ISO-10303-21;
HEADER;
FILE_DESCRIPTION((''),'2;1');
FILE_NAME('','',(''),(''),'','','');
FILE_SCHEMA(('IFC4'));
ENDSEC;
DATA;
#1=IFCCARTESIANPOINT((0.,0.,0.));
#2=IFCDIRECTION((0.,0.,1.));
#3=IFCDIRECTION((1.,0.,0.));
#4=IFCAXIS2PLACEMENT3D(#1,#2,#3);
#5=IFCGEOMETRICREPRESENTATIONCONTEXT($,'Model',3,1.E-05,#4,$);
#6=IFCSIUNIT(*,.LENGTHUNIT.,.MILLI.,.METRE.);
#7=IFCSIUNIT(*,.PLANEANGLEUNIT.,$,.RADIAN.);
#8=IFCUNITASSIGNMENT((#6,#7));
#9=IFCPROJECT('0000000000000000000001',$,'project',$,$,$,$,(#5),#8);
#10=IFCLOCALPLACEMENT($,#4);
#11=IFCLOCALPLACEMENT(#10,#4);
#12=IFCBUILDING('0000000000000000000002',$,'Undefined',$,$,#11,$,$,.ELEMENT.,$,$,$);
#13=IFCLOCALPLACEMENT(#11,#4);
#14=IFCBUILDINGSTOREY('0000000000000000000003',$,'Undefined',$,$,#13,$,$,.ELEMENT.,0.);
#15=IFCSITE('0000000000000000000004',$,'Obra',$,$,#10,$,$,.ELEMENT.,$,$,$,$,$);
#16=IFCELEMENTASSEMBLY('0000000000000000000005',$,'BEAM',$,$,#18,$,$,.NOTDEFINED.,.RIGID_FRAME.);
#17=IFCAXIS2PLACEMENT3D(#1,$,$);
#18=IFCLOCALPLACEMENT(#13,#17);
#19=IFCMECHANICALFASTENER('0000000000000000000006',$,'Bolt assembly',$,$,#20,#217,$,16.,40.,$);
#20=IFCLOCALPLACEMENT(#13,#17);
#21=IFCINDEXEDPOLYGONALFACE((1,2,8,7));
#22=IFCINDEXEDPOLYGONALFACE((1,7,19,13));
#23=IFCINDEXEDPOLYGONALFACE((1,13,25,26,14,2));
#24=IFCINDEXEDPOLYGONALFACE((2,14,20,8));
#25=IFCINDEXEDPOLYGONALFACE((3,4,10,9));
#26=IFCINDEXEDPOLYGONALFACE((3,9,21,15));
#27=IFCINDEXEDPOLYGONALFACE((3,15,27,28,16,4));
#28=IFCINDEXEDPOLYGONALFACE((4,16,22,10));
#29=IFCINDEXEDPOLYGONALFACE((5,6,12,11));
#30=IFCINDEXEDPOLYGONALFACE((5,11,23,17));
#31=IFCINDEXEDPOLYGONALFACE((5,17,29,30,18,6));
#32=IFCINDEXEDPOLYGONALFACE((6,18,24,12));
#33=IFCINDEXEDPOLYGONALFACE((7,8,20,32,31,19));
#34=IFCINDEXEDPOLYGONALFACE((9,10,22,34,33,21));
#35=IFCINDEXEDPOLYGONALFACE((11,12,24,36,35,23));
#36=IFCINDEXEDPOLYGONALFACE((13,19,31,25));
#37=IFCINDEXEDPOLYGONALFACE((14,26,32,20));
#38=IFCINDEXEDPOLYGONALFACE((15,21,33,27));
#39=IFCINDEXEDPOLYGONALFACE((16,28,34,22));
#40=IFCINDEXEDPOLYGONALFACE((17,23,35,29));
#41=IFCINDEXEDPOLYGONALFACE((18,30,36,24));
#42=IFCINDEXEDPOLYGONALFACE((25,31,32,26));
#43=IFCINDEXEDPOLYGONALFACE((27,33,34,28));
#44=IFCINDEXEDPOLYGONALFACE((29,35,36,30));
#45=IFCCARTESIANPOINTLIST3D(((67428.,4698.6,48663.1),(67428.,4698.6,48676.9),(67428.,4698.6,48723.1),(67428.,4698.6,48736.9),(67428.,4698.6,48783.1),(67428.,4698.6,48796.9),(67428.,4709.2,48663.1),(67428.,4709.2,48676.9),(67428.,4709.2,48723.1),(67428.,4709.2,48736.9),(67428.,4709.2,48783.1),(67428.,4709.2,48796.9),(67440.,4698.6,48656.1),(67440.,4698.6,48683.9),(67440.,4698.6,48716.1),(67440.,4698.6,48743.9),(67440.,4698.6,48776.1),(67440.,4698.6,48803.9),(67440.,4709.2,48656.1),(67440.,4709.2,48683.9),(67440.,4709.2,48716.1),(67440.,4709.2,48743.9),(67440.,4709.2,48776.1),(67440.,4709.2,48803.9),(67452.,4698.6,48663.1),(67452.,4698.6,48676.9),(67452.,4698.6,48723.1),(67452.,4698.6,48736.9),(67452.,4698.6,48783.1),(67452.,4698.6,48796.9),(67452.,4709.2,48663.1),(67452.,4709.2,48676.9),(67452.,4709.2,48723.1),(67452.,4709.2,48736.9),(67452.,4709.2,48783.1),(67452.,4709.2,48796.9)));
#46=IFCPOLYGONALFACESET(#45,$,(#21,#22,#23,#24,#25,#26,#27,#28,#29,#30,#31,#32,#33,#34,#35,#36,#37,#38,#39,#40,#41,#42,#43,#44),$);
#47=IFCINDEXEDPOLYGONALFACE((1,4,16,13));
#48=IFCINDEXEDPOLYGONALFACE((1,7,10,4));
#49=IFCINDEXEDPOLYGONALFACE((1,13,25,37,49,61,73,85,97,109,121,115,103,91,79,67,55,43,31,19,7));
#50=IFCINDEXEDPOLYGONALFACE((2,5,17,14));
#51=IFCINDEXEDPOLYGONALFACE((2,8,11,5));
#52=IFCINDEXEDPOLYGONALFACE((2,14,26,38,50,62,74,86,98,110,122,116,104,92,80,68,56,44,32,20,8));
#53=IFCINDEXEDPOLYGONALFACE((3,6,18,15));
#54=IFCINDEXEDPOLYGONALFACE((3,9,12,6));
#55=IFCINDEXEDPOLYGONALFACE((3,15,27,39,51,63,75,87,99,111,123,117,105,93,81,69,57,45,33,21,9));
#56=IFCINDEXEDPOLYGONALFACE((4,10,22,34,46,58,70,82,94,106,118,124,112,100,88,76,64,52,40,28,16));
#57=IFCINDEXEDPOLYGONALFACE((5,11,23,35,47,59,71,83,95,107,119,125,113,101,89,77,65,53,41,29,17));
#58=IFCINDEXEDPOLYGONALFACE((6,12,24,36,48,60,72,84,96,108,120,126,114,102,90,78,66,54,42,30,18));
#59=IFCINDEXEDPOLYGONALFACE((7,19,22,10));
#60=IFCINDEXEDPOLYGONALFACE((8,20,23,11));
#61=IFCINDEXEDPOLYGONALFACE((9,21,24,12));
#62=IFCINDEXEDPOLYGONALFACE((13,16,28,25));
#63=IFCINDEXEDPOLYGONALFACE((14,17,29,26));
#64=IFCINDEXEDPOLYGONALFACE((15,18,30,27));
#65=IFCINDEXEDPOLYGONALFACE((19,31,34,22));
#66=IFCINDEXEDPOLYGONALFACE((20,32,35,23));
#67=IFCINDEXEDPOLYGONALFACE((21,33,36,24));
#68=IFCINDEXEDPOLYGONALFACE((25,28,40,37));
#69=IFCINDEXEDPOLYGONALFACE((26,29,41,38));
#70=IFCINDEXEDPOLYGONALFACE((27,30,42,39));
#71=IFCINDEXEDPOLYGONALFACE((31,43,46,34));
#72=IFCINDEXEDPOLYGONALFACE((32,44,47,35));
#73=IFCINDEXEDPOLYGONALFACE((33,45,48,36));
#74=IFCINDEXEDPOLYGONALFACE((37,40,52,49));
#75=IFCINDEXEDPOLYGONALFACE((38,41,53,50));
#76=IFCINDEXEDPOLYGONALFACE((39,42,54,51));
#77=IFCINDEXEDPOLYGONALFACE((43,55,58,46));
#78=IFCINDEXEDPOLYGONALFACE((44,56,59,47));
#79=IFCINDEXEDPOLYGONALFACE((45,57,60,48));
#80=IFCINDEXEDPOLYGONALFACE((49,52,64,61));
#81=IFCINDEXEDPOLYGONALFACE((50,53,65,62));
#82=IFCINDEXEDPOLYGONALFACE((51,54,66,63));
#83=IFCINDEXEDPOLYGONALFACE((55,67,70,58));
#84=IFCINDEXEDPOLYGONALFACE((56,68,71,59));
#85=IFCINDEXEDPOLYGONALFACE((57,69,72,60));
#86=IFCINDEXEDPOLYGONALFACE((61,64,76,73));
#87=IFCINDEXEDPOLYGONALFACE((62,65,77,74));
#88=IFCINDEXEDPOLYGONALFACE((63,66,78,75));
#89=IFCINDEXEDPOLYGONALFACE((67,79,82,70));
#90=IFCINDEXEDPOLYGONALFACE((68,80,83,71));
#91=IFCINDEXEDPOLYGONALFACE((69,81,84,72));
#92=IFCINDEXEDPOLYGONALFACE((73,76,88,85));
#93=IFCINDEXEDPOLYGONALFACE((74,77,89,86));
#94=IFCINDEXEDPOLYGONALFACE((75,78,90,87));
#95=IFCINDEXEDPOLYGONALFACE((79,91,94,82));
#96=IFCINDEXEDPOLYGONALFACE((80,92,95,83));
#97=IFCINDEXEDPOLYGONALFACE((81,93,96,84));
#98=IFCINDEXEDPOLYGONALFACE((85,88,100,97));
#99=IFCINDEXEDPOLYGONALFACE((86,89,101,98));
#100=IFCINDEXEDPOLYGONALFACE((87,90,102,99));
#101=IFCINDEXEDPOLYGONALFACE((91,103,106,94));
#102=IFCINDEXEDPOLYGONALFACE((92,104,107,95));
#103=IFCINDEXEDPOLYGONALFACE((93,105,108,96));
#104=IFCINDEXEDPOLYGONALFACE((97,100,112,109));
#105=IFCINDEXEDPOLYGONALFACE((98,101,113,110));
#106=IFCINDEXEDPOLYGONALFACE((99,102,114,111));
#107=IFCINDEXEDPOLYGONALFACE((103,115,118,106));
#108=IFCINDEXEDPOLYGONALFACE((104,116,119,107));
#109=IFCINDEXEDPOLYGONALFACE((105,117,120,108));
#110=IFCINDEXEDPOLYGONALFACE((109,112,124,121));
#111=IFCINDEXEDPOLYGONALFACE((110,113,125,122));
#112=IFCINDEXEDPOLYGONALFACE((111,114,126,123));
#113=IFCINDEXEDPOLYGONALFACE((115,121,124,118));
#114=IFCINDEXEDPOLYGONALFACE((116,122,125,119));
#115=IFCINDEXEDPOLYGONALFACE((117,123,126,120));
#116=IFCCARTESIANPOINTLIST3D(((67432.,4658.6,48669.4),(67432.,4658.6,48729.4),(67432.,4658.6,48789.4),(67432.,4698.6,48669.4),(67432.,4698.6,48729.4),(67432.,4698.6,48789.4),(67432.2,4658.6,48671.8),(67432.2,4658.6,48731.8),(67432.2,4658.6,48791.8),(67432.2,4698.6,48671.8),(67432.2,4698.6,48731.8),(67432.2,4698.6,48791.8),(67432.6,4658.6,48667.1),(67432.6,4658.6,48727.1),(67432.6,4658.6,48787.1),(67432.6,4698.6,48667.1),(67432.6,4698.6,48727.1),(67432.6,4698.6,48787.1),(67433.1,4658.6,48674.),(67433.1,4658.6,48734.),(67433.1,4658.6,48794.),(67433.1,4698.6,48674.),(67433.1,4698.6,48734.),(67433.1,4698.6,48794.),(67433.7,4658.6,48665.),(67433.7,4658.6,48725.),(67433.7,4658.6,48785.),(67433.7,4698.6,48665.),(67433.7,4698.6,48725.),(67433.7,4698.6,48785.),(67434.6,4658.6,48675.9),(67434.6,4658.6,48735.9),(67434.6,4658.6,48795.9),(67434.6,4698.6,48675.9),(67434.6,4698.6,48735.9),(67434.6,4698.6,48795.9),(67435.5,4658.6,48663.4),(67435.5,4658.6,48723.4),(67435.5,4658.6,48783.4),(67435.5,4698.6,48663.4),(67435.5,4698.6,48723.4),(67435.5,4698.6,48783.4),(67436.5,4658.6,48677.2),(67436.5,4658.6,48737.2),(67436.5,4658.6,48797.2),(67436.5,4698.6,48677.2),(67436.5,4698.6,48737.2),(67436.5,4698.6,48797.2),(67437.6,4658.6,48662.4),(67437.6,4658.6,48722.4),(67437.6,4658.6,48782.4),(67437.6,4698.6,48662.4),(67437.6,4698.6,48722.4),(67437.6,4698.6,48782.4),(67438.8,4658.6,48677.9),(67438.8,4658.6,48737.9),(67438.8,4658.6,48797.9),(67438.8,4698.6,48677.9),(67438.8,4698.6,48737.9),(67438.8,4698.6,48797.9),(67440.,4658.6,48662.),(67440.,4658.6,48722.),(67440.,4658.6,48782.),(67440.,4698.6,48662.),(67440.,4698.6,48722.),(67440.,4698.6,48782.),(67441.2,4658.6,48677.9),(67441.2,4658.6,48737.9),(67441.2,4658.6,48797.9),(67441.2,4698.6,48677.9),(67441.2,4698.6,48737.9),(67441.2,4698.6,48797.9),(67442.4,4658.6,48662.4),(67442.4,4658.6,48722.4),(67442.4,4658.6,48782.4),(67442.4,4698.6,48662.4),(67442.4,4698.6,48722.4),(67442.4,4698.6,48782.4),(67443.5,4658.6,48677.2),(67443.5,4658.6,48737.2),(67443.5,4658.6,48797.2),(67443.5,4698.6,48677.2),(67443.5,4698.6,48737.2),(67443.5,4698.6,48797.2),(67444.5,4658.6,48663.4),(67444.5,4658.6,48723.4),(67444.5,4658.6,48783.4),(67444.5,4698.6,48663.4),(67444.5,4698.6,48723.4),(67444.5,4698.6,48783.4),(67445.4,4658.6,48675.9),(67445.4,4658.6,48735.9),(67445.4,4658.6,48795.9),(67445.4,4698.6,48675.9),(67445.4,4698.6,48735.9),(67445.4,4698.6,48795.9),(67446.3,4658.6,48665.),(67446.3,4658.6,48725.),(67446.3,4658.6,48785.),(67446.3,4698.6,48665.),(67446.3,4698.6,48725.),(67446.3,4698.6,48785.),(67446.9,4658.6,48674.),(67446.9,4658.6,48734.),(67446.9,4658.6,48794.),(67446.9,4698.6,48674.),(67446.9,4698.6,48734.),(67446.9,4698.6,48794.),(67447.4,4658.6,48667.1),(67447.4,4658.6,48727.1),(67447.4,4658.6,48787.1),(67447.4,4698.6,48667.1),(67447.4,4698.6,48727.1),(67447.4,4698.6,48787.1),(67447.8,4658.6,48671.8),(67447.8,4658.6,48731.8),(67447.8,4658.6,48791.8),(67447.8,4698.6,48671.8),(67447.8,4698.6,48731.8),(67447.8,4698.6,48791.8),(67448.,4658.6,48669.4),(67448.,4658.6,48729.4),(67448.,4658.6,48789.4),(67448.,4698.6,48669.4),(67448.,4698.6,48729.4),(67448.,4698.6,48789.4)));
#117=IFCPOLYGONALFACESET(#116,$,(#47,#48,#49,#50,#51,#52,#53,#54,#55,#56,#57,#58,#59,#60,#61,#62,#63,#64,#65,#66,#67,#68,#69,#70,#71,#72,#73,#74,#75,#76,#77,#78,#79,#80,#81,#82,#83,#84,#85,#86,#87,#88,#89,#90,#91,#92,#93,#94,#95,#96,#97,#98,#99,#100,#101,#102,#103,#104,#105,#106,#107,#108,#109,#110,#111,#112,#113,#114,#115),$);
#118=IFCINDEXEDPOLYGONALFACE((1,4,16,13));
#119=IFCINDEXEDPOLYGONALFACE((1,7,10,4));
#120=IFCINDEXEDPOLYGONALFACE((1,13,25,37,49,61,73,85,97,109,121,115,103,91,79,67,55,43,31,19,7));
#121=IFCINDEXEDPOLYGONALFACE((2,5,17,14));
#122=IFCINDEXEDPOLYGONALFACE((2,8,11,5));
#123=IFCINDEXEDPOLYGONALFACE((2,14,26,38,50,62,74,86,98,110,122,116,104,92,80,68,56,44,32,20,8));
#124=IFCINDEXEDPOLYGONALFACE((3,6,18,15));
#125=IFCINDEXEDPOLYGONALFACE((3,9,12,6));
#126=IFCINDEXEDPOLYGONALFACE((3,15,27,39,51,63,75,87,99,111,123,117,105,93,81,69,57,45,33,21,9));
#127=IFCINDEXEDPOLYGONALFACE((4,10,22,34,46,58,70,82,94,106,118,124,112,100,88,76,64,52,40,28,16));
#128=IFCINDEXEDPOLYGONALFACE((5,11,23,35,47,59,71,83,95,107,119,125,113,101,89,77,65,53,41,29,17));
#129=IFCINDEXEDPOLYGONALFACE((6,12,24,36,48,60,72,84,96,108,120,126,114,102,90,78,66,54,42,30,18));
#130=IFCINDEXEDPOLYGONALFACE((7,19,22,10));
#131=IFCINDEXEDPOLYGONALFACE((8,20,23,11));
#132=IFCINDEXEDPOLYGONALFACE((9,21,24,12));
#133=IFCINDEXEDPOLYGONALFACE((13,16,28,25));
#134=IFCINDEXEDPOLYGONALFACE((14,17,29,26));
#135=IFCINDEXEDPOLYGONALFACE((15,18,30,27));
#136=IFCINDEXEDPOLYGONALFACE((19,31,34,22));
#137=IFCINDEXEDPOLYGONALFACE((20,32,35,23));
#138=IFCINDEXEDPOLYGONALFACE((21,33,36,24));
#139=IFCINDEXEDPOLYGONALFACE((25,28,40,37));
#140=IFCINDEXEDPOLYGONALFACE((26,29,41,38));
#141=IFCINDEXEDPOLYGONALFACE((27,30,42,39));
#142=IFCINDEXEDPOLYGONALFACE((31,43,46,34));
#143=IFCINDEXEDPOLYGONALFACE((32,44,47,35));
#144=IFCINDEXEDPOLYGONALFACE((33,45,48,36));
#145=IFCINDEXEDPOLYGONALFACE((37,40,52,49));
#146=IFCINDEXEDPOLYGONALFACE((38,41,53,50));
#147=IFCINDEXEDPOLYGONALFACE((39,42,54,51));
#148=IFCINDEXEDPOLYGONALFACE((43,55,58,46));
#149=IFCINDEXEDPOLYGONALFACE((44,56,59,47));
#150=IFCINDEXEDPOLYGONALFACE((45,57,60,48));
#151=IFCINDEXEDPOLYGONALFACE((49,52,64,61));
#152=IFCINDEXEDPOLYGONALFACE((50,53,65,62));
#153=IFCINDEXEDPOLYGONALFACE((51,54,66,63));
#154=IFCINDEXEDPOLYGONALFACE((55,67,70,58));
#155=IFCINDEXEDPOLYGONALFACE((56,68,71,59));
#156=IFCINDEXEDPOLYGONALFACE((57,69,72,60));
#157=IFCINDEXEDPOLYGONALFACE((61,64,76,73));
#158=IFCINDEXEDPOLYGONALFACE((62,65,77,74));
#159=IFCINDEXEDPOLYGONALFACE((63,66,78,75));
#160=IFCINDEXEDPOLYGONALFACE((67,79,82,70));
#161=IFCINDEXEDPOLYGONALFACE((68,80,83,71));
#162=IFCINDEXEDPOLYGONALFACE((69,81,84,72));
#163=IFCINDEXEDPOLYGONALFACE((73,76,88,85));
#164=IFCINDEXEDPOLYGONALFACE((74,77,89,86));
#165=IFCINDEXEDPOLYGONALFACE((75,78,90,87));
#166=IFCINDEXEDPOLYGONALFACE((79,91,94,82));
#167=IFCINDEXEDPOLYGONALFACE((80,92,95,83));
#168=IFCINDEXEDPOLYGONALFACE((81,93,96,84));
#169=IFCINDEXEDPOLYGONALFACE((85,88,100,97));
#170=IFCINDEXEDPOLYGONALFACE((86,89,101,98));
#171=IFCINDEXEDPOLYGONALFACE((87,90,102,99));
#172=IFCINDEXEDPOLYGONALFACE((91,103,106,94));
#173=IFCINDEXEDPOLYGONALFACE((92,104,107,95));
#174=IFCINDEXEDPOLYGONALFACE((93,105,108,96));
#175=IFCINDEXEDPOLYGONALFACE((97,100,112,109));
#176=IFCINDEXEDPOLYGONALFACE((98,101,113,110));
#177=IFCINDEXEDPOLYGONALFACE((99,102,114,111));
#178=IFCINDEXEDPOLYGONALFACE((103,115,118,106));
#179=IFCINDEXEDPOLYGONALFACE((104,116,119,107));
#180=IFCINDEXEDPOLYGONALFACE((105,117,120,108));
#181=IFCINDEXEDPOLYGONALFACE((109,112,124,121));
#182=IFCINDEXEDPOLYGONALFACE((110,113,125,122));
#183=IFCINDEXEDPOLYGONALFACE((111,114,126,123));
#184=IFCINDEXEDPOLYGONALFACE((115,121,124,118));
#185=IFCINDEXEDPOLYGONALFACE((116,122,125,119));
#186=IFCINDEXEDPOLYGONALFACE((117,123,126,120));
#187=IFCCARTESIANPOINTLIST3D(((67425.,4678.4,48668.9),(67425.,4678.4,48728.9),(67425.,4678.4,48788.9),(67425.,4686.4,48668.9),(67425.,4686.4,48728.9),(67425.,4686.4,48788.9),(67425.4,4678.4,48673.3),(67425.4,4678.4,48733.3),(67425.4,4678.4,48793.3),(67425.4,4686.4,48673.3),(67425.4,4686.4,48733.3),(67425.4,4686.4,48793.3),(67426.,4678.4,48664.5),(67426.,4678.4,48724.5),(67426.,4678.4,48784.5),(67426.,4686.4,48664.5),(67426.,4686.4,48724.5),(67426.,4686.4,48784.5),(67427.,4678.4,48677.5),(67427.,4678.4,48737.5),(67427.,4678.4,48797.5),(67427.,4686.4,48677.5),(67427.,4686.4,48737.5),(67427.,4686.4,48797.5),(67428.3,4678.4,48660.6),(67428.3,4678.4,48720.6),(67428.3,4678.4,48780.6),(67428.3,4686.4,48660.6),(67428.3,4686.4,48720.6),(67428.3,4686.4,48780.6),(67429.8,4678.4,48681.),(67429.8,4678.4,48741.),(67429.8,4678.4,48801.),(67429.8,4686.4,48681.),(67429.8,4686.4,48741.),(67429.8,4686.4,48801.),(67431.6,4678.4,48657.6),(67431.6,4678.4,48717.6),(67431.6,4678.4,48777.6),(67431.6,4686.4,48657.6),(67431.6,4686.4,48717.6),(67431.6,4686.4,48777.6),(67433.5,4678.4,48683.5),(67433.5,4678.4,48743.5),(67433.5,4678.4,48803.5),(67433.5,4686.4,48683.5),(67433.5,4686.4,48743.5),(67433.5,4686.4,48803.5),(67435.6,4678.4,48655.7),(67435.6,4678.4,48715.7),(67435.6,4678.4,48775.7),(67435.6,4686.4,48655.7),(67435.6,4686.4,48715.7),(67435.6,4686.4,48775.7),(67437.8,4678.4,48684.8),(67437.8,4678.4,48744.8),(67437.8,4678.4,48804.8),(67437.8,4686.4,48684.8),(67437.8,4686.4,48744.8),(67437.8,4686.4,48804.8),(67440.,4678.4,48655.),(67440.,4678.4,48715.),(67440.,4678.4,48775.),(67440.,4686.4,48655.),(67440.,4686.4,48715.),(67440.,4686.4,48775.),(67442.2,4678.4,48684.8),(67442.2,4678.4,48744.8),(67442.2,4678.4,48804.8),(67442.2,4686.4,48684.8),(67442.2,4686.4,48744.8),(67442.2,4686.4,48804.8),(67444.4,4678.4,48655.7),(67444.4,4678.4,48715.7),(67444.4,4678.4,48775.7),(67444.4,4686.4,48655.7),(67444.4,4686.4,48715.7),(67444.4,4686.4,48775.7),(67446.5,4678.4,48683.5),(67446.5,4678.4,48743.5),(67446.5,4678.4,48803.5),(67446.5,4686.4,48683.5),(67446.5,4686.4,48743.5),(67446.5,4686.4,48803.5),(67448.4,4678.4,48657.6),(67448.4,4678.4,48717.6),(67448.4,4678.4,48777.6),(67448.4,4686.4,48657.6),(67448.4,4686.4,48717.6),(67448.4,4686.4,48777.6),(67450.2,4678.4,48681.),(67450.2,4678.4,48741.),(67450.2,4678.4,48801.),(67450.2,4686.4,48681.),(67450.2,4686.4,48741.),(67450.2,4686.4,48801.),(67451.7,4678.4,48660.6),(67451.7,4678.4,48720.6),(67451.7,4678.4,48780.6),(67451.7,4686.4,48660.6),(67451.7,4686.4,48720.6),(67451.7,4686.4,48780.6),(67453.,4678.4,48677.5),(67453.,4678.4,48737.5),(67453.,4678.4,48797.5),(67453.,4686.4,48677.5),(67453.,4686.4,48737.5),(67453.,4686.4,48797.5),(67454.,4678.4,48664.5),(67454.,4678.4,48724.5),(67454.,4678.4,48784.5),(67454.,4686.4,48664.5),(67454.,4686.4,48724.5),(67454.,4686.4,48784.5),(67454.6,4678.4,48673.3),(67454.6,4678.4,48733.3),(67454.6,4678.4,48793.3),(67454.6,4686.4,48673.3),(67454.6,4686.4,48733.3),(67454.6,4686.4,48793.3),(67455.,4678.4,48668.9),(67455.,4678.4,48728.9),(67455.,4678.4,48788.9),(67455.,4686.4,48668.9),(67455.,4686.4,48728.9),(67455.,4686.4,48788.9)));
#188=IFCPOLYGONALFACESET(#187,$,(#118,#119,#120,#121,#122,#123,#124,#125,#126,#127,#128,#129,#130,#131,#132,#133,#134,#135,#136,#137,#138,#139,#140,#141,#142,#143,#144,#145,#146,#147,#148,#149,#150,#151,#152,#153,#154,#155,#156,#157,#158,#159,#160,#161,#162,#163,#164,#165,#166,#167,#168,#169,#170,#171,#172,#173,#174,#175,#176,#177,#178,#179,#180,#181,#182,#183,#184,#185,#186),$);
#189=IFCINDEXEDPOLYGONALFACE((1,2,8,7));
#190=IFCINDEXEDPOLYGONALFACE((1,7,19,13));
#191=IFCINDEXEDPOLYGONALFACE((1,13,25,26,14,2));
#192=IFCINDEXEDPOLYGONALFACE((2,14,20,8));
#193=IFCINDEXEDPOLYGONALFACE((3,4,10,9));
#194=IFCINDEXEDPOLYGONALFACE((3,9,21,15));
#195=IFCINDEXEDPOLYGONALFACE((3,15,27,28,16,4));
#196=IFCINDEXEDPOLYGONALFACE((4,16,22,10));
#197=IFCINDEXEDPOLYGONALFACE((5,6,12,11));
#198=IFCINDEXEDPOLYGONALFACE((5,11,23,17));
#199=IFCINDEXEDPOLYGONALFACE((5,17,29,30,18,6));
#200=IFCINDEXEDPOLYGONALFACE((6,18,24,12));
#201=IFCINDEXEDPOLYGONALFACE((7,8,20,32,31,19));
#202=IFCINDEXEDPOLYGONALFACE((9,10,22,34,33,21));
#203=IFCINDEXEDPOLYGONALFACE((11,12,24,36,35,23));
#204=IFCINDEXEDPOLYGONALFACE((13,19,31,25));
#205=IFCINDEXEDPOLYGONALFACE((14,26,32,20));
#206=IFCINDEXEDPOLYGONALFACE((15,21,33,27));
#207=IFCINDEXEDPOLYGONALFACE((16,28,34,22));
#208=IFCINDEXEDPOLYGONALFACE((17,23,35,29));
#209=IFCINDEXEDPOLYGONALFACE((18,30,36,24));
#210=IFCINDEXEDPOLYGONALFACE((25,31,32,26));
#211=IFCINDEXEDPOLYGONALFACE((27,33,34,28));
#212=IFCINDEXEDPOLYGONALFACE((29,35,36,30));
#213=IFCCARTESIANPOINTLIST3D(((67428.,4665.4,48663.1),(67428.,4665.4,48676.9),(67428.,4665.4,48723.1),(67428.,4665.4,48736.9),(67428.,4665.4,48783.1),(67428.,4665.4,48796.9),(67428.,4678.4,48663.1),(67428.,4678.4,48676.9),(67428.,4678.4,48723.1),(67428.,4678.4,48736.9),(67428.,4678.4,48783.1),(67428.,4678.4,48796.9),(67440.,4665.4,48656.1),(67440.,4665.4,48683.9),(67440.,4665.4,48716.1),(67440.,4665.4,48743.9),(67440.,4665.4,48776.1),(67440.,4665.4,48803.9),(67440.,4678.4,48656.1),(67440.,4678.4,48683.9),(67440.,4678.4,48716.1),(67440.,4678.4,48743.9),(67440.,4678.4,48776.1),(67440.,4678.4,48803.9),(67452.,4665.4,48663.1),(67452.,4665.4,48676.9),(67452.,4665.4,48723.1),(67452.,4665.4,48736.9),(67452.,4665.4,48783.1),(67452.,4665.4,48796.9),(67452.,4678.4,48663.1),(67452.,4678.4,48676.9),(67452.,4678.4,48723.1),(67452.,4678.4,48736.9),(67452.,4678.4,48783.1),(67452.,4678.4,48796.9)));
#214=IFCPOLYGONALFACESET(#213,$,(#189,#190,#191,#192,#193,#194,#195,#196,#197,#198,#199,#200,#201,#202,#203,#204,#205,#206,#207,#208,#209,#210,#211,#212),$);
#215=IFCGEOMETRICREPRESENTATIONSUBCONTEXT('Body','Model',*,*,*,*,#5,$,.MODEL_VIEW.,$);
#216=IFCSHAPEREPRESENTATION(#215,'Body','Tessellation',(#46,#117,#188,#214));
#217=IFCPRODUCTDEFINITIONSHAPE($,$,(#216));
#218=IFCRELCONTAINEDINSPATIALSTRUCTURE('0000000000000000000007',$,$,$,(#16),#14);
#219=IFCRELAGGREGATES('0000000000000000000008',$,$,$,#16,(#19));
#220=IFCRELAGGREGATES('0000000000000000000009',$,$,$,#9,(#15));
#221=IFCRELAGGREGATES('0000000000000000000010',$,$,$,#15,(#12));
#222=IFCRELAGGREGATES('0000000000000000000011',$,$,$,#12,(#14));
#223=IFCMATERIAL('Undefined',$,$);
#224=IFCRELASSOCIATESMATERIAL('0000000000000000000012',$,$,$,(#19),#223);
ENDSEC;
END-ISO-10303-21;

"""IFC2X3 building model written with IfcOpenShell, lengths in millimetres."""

from ifc_helpers import new_model, si_unit, frame, origin_with_axes, origin_2d_with_axis, place, context, subcontext, project, spatial, polyline, circle, outline, extrude, source, transform, mapped, material, element, aggregate, save


model = new_model("IFC2X3")

# Units and contexts
model_context = context("Model", 3, precision=1e-05, world=origin_with_axes())
body_context = subcontext(model_context, "Body", "Model", "MODEL_VIEW")
ifc_project = project(units=[si_unit("LENGTHUNIT", "METRE", prefix="MILLI"), si_unit("PLANEANGLEUNIT", "RADIAN")], contexts=[model_context])

# Site, building, storey
site_placement = place(None, origin_with_axes())
site = spatial("IfcSite", under=ifc_project, at=site_placement, Name="Obra", CompositionType="ELEMENT")
building_placement = place(site_placement, origin_with_axes())
building = spatial("IfcBuilding", under=site, at=building_placement, Name="Undefined", CompositionType="ELEMENT")
storey_placement = place(building_placement, origin_with_axes())
storey = spatial("IfcBuildingStorey", under=building, at=storey_placement, Name="Undefined", CompositionType="ELEMENT", Elevation=0.0)

# Element assembly, mechanical fastener
ifc_material_1 = material(Name="Undefined")
shared_shape_1 = source(origin_with_axes(), body_context, "Body", "SweptSolid", [
    extrude(outline(polyline([(13.9, 0.0), (6.9, 12.0), (-6.9, 12.0), (-13.9, 0.0), (-6.9, -12.0), (6.9, -12.0), (13.9, 0.0)])), frame((0.0, -19.7, 0.0), z_axis=(0.0, 1.0, 0.0), x_axis=(1.0, 0.0, 0.0)), (0.0, 0.0, 1.0), 10.6),
    extrude(circle(Radius=8.0, at=origin_2d_with_axis()), frame((0.0, -9.1, 0.0), z_axis=(0.0, 1.0, 0.0), x_axis=(1.0, 0.0, 0.0)), (0.0, 0.0, 1.0), 40.0),
    extrude(circle(Radius=15.0, at=origin_2d_with_axis()), frame((0.0, 3.1, 0.0), z_axis=(0.0, 1.0, 0.0), x_axis=(1.0, 0.0, 0.0)), (0.0, 0.0, 1.0), 8.0),
    extrude(outline(polyline([(13.9, 0.0), (6.9, 12.0), (-6.9, 12.0), (-13.9, 0.0), (-6.9, -12.0), (6.9, -12.0), (13.9, 0.0)])), frame((0.0, 11.1, 0.0), z_axis=(0.0, 1.0, 0.0), x_axis=(1.0, 0.0, 0.0)), (0.0, 0.0, 1.0), 13.0),
])
assembly_1_placement = place(storey_placement, origin_with_axes())
assembly_1 = element("IfcElementAssembly", 1, at=assembly_1_placement, inside=storey, Name="BEAM", AssemblyPlace="NOTDEFINED", PredefinedType="RIGID_FRAME")
mechanical_fastener_1_placement = place(assembly_1_placement, frame((67490.0, 4689.5, 48850.0), z_axis=(-1.0, 0.0, 0.0), x_axis=(0.0, 0.0, -1.0)))
mechanical_fastener_1 = element("IfcMechanicalFastener", 2, at=mechanical_fastener_1_placement, material=ifc_material_1, Name="Bolt assembly", NominalDiameter=16.0, NominalLength=40.0, context=body_context, shape_type="MappedRepresentation", body=[
    mapped(shared_shape_1, transform((60.0, 0.0, 50.0))),
    mapped(shared_shape_1, transform((120.0, 0.0, 50.0))),
    mapped(shared_shape_1, transform((180.0, 0.0, 50.0))),
])
aggregate(assembly_1, [mechanical_fastener_1])

save(model, "model.ifc")
